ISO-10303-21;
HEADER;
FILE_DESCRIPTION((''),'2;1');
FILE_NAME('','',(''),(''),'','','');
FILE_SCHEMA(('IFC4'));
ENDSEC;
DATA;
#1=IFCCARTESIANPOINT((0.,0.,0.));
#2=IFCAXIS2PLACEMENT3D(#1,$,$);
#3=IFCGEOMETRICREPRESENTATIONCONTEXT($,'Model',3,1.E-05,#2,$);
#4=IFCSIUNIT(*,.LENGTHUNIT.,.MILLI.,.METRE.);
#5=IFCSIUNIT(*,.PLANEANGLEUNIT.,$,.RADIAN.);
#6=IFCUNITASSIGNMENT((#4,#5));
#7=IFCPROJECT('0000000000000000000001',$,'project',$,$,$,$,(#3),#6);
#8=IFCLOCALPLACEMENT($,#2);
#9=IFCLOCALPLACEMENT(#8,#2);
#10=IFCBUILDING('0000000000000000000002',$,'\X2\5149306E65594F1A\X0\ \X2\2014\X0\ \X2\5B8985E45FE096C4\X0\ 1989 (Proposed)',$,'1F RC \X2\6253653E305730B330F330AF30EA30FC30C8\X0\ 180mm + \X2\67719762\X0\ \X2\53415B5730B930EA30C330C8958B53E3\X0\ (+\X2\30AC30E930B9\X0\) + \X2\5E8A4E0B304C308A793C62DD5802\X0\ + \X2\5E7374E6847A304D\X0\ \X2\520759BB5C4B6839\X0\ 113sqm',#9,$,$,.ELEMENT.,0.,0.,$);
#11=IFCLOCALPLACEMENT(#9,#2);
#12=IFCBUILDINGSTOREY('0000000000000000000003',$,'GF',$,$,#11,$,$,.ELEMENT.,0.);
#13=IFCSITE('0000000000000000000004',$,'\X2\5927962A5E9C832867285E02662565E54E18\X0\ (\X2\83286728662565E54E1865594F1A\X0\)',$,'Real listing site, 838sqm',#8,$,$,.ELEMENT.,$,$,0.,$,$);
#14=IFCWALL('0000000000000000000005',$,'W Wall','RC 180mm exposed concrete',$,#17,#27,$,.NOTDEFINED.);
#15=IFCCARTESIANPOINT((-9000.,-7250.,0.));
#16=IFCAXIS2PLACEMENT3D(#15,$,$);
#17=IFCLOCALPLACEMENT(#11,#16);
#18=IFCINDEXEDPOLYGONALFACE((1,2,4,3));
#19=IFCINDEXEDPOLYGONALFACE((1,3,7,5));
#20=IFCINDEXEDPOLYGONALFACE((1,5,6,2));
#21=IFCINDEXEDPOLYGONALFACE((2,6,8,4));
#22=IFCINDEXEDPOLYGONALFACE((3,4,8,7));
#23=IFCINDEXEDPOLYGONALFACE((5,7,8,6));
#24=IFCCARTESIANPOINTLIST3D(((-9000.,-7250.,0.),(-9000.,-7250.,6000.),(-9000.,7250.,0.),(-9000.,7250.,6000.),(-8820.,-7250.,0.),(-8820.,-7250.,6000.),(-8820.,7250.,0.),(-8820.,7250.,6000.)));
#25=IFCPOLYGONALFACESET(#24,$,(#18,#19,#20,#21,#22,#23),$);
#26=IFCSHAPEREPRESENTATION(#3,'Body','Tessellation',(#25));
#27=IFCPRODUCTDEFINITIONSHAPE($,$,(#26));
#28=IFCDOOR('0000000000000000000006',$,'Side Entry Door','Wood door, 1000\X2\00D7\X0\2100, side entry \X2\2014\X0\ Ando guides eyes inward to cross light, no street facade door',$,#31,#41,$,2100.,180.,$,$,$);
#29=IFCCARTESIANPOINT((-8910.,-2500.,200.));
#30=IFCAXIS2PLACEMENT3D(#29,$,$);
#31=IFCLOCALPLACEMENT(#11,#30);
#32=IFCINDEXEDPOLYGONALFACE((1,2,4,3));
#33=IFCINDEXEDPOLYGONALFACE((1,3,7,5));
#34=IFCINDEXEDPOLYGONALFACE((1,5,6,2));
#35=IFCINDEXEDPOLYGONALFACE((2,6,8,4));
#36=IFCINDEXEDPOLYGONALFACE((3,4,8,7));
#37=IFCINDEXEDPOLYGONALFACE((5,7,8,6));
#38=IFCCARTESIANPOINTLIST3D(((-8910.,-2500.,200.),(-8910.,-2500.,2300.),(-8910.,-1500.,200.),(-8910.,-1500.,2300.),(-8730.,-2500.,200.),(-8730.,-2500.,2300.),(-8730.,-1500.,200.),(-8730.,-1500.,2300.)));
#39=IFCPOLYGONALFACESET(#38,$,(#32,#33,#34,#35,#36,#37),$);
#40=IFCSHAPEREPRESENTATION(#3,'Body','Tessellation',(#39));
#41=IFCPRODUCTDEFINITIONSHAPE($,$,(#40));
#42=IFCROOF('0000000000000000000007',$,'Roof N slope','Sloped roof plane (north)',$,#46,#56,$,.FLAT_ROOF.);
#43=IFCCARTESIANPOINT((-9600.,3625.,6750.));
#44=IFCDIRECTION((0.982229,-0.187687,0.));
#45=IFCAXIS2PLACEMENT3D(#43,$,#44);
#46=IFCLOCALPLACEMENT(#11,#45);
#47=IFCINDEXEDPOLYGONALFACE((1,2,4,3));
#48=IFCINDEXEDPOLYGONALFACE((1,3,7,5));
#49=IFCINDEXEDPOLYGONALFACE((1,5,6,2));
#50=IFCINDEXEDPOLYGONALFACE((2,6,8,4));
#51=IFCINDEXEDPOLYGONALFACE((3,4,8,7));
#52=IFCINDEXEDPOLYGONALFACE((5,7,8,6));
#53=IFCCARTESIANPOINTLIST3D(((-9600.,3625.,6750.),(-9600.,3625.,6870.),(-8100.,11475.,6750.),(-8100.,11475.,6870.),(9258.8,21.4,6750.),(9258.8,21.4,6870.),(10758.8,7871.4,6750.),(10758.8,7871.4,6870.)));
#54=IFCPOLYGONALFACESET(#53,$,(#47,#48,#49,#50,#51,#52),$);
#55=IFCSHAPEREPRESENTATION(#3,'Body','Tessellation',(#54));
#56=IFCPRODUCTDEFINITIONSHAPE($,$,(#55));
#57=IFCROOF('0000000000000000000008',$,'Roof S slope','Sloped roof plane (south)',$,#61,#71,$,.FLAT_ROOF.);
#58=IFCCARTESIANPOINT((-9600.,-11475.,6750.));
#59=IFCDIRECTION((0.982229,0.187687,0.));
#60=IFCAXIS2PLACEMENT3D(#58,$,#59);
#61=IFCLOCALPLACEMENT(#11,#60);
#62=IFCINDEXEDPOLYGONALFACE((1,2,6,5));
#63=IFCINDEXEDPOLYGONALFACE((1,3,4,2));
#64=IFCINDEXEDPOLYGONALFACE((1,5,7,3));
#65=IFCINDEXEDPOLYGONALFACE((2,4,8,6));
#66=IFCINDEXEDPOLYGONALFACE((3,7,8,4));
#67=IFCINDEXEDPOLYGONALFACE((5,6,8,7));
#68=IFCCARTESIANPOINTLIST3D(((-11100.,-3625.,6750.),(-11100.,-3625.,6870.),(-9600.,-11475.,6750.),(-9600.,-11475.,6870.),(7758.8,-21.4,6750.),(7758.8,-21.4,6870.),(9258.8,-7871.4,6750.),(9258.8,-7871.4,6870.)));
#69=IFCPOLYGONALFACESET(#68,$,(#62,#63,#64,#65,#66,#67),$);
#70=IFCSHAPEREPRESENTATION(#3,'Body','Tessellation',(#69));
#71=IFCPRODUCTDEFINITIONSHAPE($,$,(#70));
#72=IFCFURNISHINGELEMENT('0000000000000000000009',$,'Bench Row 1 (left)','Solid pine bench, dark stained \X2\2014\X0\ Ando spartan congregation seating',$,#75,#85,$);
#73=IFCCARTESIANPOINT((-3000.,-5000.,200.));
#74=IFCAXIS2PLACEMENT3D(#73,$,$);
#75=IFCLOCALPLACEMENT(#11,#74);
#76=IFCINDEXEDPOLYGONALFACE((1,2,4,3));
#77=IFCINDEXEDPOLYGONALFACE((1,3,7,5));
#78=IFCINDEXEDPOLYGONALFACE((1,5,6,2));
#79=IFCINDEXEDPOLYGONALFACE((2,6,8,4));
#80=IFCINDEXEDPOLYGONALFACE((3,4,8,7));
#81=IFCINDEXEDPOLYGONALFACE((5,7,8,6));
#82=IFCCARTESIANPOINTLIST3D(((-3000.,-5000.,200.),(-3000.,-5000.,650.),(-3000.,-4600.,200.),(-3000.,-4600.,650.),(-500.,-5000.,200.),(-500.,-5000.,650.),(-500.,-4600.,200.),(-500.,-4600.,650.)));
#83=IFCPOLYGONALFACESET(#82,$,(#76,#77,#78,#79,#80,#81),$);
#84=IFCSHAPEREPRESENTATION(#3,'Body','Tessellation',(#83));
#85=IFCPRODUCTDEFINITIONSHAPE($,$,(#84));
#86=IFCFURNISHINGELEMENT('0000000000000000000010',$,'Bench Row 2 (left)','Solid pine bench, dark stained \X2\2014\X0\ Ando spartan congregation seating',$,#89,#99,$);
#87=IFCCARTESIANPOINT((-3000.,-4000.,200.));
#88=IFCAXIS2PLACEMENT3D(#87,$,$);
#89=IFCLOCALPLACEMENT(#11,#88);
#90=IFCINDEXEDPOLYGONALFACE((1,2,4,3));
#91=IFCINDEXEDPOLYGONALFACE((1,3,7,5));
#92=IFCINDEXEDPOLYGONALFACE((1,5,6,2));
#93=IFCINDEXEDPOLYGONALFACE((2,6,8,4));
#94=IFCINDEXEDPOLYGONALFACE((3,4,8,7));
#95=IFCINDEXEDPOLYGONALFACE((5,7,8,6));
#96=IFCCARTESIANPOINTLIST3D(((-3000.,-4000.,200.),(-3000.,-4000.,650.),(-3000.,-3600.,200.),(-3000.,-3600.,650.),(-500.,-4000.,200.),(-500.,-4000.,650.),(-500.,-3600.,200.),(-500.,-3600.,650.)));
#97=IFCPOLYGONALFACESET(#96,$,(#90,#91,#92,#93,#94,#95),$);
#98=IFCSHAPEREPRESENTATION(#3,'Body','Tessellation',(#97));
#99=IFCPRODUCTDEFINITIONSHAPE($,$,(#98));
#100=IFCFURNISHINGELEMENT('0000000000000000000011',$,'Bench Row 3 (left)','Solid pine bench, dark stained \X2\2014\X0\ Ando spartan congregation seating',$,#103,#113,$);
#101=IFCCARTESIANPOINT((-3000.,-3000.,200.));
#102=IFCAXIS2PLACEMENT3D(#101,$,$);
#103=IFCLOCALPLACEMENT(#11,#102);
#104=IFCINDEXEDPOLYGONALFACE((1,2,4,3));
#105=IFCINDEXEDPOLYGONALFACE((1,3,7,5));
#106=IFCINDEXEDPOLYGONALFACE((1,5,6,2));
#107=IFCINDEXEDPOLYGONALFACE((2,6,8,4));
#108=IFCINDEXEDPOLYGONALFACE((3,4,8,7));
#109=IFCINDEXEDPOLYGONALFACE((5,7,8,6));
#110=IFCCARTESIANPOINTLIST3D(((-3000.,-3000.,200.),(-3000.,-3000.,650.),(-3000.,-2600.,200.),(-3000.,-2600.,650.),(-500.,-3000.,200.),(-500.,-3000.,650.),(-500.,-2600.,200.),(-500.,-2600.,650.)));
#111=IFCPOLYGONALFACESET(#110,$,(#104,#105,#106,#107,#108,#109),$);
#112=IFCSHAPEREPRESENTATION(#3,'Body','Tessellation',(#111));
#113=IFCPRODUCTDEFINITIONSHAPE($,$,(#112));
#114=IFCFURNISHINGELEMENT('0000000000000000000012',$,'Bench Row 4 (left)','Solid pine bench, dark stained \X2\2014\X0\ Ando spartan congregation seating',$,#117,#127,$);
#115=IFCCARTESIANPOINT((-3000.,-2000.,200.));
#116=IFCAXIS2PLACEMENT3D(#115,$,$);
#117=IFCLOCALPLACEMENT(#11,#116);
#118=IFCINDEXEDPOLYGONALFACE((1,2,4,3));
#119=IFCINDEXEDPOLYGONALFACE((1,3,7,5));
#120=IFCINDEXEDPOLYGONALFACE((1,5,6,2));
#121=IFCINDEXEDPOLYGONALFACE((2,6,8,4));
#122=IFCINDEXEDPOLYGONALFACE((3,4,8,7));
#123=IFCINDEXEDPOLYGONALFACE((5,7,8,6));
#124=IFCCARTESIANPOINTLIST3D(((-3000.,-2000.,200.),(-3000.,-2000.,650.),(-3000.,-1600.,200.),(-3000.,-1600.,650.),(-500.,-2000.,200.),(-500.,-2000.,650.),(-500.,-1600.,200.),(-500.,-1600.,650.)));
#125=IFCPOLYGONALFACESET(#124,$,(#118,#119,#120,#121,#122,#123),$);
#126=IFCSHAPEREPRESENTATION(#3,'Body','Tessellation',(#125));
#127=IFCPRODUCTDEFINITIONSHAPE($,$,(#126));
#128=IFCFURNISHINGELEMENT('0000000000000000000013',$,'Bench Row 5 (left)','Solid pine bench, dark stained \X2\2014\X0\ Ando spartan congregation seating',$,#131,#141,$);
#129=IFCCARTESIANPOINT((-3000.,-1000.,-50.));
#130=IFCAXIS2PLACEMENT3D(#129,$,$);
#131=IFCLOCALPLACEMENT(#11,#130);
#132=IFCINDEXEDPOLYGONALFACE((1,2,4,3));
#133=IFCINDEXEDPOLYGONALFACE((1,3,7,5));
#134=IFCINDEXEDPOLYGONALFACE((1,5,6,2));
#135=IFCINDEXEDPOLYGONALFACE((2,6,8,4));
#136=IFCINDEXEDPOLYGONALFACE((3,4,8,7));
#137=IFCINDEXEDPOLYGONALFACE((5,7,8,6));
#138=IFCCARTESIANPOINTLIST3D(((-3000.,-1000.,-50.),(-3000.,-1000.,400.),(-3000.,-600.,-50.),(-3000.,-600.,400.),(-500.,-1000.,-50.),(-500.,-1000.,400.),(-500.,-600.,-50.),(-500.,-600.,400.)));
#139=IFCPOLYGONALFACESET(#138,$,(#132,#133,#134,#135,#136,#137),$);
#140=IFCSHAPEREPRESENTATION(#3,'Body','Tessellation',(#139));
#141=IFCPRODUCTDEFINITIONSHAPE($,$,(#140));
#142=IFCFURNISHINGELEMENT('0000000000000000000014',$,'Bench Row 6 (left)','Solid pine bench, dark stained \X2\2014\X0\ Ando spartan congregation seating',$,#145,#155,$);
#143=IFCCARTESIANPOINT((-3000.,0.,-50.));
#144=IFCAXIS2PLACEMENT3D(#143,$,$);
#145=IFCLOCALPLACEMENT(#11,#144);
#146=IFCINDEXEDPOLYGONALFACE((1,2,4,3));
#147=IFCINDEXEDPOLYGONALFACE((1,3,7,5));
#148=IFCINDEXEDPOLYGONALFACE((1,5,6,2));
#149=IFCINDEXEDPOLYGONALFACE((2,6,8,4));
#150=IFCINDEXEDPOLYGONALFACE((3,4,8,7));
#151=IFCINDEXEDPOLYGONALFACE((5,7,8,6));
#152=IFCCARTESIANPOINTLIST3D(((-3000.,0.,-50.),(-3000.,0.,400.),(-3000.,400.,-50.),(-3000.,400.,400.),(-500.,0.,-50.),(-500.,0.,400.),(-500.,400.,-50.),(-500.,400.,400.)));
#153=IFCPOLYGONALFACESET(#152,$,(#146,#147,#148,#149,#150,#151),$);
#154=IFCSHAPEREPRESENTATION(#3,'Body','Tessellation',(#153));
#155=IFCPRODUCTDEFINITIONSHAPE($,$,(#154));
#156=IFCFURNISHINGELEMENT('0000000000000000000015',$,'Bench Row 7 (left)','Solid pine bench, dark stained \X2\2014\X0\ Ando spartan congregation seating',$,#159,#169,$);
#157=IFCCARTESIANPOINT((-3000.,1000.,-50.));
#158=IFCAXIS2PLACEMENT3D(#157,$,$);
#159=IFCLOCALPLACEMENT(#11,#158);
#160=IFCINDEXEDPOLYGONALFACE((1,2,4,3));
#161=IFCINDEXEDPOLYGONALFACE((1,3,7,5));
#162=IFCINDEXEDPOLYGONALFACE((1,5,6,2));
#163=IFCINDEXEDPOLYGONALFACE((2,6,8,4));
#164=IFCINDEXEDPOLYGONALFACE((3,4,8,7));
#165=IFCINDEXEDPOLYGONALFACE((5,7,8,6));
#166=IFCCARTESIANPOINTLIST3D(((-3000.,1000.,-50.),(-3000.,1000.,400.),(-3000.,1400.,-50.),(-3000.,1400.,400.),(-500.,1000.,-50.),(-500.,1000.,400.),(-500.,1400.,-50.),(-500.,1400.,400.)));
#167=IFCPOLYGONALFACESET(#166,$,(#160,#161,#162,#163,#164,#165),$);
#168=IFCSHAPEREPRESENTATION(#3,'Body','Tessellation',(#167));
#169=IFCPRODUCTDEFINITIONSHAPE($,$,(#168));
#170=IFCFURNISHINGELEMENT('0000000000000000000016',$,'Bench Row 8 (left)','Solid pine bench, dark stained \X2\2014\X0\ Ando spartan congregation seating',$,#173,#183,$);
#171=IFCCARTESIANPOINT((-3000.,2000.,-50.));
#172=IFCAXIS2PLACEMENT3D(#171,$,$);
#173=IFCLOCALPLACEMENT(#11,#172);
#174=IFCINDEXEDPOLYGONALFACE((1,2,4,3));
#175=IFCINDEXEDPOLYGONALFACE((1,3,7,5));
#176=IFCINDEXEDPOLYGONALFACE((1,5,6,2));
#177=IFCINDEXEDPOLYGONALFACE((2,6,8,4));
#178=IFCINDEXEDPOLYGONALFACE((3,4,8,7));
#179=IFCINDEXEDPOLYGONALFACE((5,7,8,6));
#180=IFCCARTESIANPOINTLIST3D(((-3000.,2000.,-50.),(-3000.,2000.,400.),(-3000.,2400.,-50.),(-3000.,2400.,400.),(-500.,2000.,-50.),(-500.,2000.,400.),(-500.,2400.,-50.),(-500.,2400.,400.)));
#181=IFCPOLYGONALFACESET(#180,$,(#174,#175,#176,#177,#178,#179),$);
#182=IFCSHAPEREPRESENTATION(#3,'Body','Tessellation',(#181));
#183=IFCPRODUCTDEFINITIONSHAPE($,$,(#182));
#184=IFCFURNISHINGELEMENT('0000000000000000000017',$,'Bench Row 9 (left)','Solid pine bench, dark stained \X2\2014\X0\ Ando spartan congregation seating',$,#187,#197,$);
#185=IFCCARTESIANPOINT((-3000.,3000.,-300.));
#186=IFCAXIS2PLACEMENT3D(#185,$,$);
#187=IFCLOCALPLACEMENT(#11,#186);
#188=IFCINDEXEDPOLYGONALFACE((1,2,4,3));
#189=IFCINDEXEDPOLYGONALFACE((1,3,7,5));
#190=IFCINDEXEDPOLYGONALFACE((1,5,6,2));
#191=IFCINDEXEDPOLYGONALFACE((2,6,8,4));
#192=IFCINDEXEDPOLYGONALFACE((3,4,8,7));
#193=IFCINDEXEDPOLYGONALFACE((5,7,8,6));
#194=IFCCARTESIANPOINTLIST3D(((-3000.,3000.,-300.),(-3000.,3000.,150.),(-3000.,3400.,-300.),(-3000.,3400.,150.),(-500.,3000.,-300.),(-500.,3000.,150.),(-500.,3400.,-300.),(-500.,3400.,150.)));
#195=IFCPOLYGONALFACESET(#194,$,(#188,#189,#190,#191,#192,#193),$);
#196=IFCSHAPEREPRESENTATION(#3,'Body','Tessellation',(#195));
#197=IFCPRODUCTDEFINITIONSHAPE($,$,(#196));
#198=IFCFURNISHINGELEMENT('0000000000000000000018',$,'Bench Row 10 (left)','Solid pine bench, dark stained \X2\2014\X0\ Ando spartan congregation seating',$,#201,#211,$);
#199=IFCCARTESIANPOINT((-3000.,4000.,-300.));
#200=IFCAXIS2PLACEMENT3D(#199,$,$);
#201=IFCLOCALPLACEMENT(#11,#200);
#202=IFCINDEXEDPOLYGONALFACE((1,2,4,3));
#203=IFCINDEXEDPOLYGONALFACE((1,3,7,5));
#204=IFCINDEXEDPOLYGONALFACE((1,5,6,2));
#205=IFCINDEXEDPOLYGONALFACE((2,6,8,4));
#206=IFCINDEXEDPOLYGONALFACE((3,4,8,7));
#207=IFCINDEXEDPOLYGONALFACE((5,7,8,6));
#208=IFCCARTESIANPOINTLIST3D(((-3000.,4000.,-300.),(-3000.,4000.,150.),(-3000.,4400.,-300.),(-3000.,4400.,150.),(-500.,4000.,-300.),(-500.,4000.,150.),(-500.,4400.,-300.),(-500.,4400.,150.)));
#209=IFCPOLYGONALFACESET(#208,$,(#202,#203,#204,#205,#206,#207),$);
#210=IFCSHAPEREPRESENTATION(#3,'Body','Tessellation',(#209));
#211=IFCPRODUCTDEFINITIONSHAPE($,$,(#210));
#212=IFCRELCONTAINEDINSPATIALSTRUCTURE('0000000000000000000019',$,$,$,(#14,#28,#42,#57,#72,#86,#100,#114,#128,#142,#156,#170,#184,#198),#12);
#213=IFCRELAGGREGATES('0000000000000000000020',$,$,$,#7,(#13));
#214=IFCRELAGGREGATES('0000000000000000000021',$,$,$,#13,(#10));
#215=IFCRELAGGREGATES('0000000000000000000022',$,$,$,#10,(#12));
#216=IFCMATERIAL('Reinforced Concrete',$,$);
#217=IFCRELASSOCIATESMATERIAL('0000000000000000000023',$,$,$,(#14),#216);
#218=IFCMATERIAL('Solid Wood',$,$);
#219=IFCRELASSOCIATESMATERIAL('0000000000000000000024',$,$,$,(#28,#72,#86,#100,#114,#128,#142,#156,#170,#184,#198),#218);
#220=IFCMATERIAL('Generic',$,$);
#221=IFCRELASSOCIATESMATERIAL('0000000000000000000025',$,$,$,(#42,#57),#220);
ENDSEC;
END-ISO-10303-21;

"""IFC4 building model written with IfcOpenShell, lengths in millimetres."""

from ifc_helpers import new_model, si_unit, frame, frame_2d, origin, place, context, project, spatial, rectangle, extrude, material, element, fill, save


model = new_model("IFC4")

# Units and contexts
model_context = context("Model", 3, precision=1e-05, world=origin())
ifc_project = project(units=[si_unit("LENGTHUNIT", "METRE", prefix="MILLI"), si_unit("PLANEANGLEUNIT", "RADIAN")], contexts=[model_context])

# Site, building, storey
site_placement = place(None, origin())
site = spatial("IfcSite", under=ifc_project, at=site_placement, Name="大阪府茨木市春日丘 (茨木春日丘教会)", ObjectType="Real listing site, 838sqm", CompositionType="ELEMENT", RefElevation=0.0)
building_placement = place(site_placement, origin())
building = spatial("IfcBuilding", under=site, at=building_placement, Name="光の教会 — 安藤忠雄 1989 (Proposed)", ObjectType="1F RC 打放しコンクリート 180mm + 東面 十字スリット開口 (+ガラス) + 床下がり礼拝堂 + 平瓦葺き 切妻屋根 113sqm", CompositionType="ELEMENT", ElevationOfRefHeight=0.0, ElevationOfTerrain=0.0)
storey_placement = place(building_placement, origin())
storey = spatial("IfcBuildingStorey", under=building, at=storey_placement, Name="GF", CompositionType="ELEMENT", Elevation=0.0)

# Shared definitions
ifc_material_1 = material(Name="Generic")

# Shared definitions
ifc_material_2 = material(Name="Reinforced Concrete")

# Wall, opening, door
wall_1_placement = place(storey_placement, frame((-9000.0, -7250.0, 0.0)))
wall_1 = element("IfcWall", 1, at=wall_1_placement, inside=storey, material=ifc_material_2, Name="W Wall", Description="RC 180mm exposed concrete", PredefinedType="NOTDEFINED", context=model_context, shape_type="SweptSolid", body=[
    extrude(rectangle(XDim=180.0, YDim=14500.0, at=frame_2d((90.0, 7250.0))), frame((-9000.0, -7250.0, 0.0)), (0.0, 0.0, 1.0), 6000.0),
])
opening_1_placement = place(storey_placement, frame((-8910.0, -2500.0, 200.0)))
opening_1 = element("IfcOpeningElement", 2, at=opening_1_placement, cuts=wall_1, PredefinedType="NOTDEFINED", context=model_context, shape_type="SweptSolid", body=[
    extrude(rectangle(XDim=180.0, YDim=1000.0, at=frame_2d((90.0, 500.0))), frame((-8910.0, -2500.0, 200.0)), (0.0, 0.0, 1.0), 2100.0),
])
ifc_material_3 = material(Name="Solid Wood")
door_placement = place(storey_placement, frame((-8910.0, -2500.0, 200.0)))
door = element("IfcDoor", 3, at=door_placement, inside=storey, material=ifc_material_3, Name="Side Entry Door", Description="Wood door, 1000×2100, side entry — Ando guides eyes inward to cross light, no street facade door", OverallHeight=2100.0, OverallWidth=180.0, context=model_context, shape_type="SweptSolid", body=[
    extrude(rectangle(XDim=180.0, YDim=1000.0, at=frame_2d((90.0, 500.0))), frame((-8910.0, -2500.0, 200.0)), (0.0, 0.0, 1.0), 2100.0),
])
fill(opening_1, door)

# Roofs
roof_1_placement = place(storey_placement, frame((-9600.0, 3625.0, 6750.0), x_axis=(0.982229, -0.187687, 0.0)))
element("IfcRoof", 4, at=roof_1_placement, inside=storey, material=ifc_material_1, Name="Roof N slope", Description="Sloped roof plane (north)", PredefinedType="FLAT_ROOF", context=model_context, shape_type="SweptSolid", body=[
    extrude(rectangle(XDim=19200.0, YDim=7992.0, at=frame_2d((9600.0, 3996.0))), frame((-9600.0, 3625.0, 6750.0), x_axis=(0.982229, -0.187687, 0.0)), (0.0, 0.0, 1.0), 120.0),
])
roof_2_placement = place(storey_placement, frame((-9600.0, -11475.0, 6750.0), x_axis=(0.982229, 0.187687, 0.0)))
element("IfcRoof", 5, at=roof_2_placement, inside=storey, material=ifc_material_1, Name="Roof S slope", Description="Sloped roof plane (south)", PredefinedType="FLAT_ROOF", context=model_context, shape_type="SweptSolid", body=[
    extrude(rectangle(XDim=19200.0, YDim=7992.0, at=frame_2d((9600.0, 3996.0))), frame((-9600.0, -11475.0, 6750.0), x_axis=(0.982229, 0.187687, 0.0)), (0.0, 0.0, 1.0), 120.0),
])

# Furnishing elements
furnishing_1_placement = place(storey_placement, frame((-3000.0, -5000.0, 200.0)))
element("IfcFurnishingElement", 6, at=furnishing_1_placement, inside=storey, material=ifc_material_3, Name="Bench Row 1 (left)", Description="Solid pine bench, dark stained — Ando spartan congregation seating", context=model_context, shape_type="SweptSolid", body=[
    extrude(rectangle(XDim=2500.0, YDim=400.0, at=frame_2d((1250.0, 200.0))), frame((-3000.0, -5000.0, 200.0)), (0.0, 0.0, 1.0), 450.0),
])
furnishing_2_placement = place(storey_placement, frame((-3000.0, -4000.0, 200.0)))
element("IfcFurnishingElement", 7, at=furnishing_2_placement, inside=storey, material=ifc_material_3, Name="Bench Row 2 (left)", Description="Solid pine bench, dark stained — Ando spartan congregation seating", context=model_context, shape_type="SweptSolid", body=[
    extrude(rectangle(XDim=2500.0, YDim=400.0, at=frame_2d((1250.0, 200.0))), frame((-3000.0, -4000.0, 200.0)), (0.0, 0.0, 1.0), 450.0),
])
furnishing_3_placement = place(storey_placement, frame((-3000.0, -3000.0, 200.0)))
element("IfcFurnishingElement", 8, at=furnishing_3_placement, inside=storey, material=ifc_material_3, Name="Bench Row 3 (left)", Description="Solid pine bench, dark stained — Ando spartan congregation seating", context=model_context, shape_type="SweptSolid", body=[
    extrude(rectangle(XDim=2500.0, YDim=400.0, at=frame_2d((1250.0, 200.0))), frame((-3000.0, -3000.0, 200.0)), (0.0, 0.0, 1.0), 450.0),
])
furnishing_4_placement = place(storey_placement, frame((-3000.0, -2000.0, 200.0)))
element("IfcFurnishingElement", 9, at=furnishing_4_placement, inside=storey, material=ifc_material_3, Name="Bench Row 4 (left)", Description="Solid pine bench, dark stained — Ando spartan congregation seating", context=model_context, shape_type="SweptSolid", body=[
    extrude(rectangle(XDim=2500.0, YDim=400.0, at=frame_2d((1250.0, 200.0))), frame((-3000.0, -2000.0, 200.0)), (0.0, 0.0, 1.0), 450.0),
])
furnishing_5_placement = place(storey_placement, frame((-3000.0, -1000.0, -50.0)))
element("IfcFurnishingElement", 10, at=furnishing_5_placement, inside=storey, material=ifc_material_3, Name="Bench Row 5 (left)", Description="Solid pine bench, dark stained — Ando spartan congregation seating", context=model_context, shape_type="SweptSolid", body=[
    extrude(rectangle(XDim=2500.0, YDim=400.0, at=frame_2d((1250.0, 200.0))), frame((-3000.0, -1000.0, -50.0)), (0.0, 0.0, 1.0), 450.0),
])
furnishing_6_placement = place(storey_placement, frame((-3000.0, 0.0, -50.0)))
element("IfcFurnishingElement", 11, at=furnishing_6_placement, inside=storey, material=ifc_material_3, Name="Bench Row 6 (left)", Description="Solid pine bench, dark stained — Ando spartan congregation seating", context=model_context, shape_type="SweptSolid", body=[
    extrude(rectangle(XDim=2500.0, YDim=400.0, at=frame_2d((1250.0, 200.0))), frame((-3000.0, 0.0, -50.0)), (0.0, 0.0, 1.0), 450.0),
])
furnishing_7_placement = place(storey_placement, frame((-3000.0, 1000.0, -50.0)))
element("IfcFurnishingElement", 12, at=furnishing_7_placement, inside=storey, material=ifc_material_3, Name="Bench Row 7 (left)", Description="Solid pine bench, dark stained — Ando spartan congregation seating", context=model_context, shape_type="SweptSolid", body=[
    extrude(rectangle(XDim=2500.0, YDim=400.0, at=frame_2d((1250.0, 200.0))), frame((-3000.0, 1000.0, -50.0)), (0.0, 0.0, 1.0), 450.0),
])
furnishing_8_placement = place(storey_placement, frame((-3000.0, 2000.0, -50.0)))
element("IfcFurnishingElement", 13, at=furnishing_8_placement, inside=storey, material=ifc_material_3, Name="Bench Row 8 (left)", Description="Solid pine bench, dark stained — Ando spartan congregation seating", context=model_context, shape_type="SweptSolid", body=[
    extrude(rectangle(XDim=2500.0, YDim=400.0, at=frame_2d((1250.0, 200.0))), frame((-3000.0, 2000.0, -50.0)), (0.0, 0.0, 1.0), 450.0),
])
furnishing_9_placement = place(storey_placement, frame((-3000.0, 3000.0, -300.0)))
element("IfcFurnishingElement", 14, at=furnishing_9_placement, inside=storey, material=ifc_material_3, Name="Bench Row 9 (left)", Description="Solid pine bench, dark stained — Ando spartan congregation seating", context=model_context, shape_type="SweptSolid", body=[
    extrude(rectangle(XDim=2500.0, YDim=400.0, at=frame_2d((1250.0, 200.0))), frame((-3000.0, 3000.0, -300.0)), (0.0, 0.0, 1.0), 450.0),
])
furnishing_10_placement = place(storey_placement, frame((-3000.0, 4000.0, -300.0)))
element("IfcFurnishingElement", 15, at=furnishing_10_placement, inside=storey, material=ifc_material_3, Name="Bench Row 10 (left)", Description="Solid pine bench, dark stained — Ando spartan congregation seating", context=model_context, shape_type="SweptSolid", body=[
    extrude(rectangle(XDim=2500.0, YDim=400.0, at=frame_2d((1250.0, 200.0))), frame((-3000.0, 4000.0, -300.0)), (0.0, 0.0, 1.0), 450.0),
])

save(model, "model.ifc")
